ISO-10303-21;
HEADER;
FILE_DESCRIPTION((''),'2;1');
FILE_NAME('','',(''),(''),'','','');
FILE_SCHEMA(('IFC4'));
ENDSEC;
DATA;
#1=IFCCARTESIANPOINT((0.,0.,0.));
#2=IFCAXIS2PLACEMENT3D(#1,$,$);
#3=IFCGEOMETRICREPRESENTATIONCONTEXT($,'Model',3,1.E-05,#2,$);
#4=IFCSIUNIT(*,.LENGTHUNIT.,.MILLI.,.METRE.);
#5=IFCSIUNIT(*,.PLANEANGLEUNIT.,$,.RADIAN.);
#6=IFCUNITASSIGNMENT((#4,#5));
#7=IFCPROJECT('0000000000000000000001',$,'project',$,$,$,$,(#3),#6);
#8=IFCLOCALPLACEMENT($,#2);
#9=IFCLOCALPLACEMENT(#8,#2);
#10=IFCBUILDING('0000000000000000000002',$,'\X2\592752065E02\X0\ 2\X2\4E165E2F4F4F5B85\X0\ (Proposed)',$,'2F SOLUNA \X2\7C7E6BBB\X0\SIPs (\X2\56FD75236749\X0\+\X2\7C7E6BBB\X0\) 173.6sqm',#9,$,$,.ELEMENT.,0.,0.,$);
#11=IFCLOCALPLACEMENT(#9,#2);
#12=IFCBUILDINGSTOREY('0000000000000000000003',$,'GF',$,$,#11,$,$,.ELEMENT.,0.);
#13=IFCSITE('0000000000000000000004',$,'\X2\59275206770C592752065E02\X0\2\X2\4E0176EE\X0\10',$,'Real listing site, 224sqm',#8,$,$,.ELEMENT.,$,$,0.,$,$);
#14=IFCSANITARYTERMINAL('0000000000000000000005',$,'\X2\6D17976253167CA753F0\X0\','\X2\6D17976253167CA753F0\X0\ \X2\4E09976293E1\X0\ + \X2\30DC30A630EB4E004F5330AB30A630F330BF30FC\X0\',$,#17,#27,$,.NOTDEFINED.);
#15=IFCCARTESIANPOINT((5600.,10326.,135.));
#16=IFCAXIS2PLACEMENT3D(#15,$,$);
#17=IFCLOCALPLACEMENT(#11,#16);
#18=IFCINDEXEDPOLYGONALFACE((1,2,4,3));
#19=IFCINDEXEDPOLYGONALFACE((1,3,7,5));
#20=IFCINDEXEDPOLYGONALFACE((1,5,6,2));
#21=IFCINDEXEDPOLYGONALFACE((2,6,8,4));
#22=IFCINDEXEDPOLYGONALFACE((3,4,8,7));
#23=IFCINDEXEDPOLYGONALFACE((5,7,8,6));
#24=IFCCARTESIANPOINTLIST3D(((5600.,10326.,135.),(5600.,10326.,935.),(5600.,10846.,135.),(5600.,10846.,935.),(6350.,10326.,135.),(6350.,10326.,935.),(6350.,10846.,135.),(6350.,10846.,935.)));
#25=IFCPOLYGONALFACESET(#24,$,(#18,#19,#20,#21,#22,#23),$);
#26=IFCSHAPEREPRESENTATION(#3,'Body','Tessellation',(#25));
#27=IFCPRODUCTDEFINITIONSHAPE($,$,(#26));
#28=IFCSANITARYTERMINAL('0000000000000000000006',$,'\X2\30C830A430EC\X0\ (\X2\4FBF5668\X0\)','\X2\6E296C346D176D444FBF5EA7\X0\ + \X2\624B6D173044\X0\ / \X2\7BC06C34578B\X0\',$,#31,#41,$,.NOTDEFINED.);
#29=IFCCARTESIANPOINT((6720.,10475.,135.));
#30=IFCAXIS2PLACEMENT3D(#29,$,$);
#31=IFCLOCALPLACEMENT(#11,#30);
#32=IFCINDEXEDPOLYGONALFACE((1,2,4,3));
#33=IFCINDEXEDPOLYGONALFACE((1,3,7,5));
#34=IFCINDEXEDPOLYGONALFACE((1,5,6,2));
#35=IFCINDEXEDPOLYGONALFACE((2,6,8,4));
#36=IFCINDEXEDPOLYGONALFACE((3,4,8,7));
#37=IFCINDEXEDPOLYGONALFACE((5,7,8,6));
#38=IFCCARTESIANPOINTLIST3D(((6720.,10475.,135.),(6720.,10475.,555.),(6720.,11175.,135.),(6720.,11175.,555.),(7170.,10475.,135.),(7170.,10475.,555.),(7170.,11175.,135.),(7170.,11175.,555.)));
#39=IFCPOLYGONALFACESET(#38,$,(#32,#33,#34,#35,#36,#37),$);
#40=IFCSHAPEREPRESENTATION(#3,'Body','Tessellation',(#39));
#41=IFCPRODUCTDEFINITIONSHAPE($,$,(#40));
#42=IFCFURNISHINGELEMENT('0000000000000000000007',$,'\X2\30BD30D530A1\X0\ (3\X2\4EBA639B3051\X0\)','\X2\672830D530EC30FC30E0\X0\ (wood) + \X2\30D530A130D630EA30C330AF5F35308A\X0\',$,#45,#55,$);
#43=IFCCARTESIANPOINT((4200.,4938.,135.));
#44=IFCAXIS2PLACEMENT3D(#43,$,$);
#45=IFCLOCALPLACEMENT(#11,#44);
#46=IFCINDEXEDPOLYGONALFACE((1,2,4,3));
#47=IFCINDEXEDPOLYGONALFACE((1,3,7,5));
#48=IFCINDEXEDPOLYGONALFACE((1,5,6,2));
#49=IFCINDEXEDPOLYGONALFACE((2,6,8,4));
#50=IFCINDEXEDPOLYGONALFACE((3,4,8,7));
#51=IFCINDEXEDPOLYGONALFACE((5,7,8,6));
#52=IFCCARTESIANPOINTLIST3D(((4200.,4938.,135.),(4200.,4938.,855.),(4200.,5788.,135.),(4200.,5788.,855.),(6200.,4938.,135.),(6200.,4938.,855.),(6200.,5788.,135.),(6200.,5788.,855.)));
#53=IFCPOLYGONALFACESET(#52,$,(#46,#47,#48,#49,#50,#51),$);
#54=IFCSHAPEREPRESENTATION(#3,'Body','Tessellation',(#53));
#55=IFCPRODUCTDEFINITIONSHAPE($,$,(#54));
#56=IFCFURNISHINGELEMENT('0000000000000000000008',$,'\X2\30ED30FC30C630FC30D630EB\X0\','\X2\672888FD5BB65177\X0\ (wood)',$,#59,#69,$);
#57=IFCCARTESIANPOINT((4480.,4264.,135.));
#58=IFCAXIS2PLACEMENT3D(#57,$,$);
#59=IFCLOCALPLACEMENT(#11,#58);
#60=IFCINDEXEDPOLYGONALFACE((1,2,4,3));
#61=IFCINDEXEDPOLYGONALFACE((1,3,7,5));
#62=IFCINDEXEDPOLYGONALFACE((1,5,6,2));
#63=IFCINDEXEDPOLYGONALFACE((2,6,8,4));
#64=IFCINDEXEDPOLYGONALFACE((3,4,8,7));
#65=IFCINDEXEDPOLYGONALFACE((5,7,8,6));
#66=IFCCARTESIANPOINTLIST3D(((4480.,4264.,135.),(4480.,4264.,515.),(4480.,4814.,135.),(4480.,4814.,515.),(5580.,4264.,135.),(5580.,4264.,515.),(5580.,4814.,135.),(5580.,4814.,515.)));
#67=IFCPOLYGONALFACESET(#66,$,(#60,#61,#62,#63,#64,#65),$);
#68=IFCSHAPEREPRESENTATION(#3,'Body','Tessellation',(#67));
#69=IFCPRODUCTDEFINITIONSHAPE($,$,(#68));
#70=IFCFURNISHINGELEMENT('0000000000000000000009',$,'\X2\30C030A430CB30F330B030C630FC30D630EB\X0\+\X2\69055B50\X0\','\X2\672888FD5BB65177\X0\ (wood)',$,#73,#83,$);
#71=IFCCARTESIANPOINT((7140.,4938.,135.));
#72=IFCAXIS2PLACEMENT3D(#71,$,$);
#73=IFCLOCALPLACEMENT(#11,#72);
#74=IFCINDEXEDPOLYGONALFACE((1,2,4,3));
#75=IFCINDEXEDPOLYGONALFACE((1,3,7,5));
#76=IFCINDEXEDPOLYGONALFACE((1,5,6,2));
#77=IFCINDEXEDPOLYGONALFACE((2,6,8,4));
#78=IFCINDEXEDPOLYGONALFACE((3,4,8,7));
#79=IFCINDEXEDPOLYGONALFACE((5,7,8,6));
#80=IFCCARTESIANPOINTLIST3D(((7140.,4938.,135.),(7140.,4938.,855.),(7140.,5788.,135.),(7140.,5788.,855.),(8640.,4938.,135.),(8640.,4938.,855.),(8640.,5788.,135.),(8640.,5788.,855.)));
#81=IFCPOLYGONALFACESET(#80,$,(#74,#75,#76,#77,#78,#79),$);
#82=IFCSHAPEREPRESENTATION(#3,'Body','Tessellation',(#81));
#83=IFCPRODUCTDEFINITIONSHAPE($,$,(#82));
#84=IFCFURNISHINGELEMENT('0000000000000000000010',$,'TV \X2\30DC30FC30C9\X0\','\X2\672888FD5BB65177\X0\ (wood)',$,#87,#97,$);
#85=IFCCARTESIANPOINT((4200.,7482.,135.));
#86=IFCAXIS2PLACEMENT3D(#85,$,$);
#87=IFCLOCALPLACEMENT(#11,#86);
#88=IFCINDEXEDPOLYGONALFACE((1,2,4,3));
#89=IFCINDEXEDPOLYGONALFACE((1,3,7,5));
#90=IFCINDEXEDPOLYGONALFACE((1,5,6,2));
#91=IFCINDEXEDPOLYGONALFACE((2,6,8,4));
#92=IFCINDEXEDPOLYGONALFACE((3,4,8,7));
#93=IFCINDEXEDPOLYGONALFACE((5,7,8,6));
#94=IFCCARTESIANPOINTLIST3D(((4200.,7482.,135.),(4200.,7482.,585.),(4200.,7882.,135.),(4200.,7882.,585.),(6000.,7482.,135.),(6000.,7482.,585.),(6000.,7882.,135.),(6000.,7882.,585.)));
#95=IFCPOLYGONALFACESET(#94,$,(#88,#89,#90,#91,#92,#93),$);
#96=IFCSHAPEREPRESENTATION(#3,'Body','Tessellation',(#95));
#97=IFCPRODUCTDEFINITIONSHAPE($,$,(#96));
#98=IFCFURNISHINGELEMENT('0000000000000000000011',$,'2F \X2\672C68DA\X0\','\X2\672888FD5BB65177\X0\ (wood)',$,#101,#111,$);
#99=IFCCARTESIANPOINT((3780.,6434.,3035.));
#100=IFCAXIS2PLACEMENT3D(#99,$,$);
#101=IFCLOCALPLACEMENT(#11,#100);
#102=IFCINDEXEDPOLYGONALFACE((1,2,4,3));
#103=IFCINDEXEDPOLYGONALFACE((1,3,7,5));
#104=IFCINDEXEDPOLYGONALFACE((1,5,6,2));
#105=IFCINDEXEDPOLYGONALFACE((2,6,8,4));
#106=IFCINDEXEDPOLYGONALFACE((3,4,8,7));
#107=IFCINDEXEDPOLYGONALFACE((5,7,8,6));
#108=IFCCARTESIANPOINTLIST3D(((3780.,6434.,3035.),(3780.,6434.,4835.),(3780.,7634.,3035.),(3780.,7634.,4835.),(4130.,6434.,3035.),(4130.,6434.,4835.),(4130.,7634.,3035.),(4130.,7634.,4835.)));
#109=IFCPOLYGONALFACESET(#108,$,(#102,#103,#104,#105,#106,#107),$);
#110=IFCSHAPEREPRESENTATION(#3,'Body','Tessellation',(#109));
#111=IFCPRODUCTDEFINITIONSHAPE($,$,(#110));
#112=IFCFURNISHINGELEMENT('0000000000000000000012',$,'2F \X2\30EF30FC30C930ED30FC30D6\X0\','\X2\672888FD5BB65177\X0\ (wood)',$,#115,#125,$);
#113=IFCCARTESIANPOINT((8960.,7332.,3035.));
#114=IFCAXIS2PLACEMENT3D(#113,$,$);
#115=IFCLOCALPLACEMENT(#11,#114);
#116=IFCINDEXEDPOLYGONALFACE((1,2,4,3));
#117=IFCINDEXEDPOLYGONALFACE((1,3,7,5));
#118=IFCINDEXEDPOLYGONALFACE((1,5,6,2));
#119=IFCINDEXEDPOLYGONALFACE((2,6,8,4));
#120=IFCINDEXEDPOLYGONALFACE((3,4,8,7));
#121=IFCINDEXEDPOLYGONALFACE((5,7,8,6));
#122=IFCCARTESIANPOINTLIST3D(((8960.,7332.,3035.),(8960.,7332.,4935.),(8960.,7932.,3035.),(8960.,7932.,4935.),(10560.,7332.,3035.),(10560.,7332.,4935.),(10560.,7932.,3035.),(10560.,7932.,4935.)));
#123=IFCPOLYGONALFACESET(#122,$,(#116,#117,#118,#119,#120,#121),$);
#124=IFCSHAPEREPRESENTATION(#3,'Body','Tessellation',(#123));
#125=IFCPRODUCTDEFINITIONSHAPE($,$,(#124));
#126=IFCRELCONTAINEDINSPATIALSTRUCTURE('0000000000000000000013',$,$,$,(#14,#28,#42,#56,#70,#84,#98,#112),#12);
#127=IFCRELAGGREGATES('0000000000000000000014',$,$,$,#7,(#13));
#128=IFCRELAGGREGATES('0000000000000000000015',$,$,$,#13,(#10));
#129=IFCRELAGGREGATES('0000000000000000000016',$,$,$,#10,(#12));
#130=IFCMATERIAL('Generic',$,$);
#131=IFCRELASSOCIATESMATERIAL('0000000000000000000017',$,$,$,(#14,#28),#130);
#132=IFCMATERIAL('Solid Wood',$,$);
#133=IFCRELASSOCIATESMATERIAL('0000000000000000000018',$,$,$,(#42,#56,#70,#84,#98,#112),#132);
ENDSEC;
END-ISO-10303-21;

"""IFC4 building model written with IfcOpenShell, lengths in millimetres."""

from ifc_helpers import new_model, si_unit, frame, frame_2d, origin, place, context, project, spatial, rectangle, extrude, material, element, save


model = new_model("IFC4")

# Units and contexts
model_context = context("Model", 3, precision=1e-05, world=origin())
ifc_project = project(units=[si_unit("LENGTHUNIT", "METRE", prefix="MILLI"), si_unit("PLANEANGLEUNIT", "RADIAN")], contexts=[model_context])

# Site, building, storey
site_placement = place(None, origin())
site = spatial("IfcSite", under=ifc_project, at=site_placement, Name="大分県大分市2丁目10", ObjectType="Real listing site, 224sqm", CompositionType="ELEMENT", RefElevation=0.0)
building_placement = place(site_placement, origin())
building = spatial("IfcBuilding", under=site, at=building_placement, Name="大分市 2世帯住宅 (Proposed)", ObjectType="2F SOLUNA 籾殻SIPs (国産杉+籾殻) 173.6sqm", CompositionType="ELEMENT", ElevationOfRefHeight=0.0, ElevationOfTerrain=0.0)
storey_placement = place(building_placement, origin())
storey = spatial("IfcBuildingStorey", under=building, at=storey_placement, Name="GF", CompositionType="ELEMENT", Elevation=0.0)

# Shared definitions
ifc_material_1 = material(Name="Generic")

# Shared definitions
ifc_material_2 = material(Name="Solid Wood")

# Sanitary terminals
sanitary_terminal_1_placement = place(storey_placement, frame((5600.0, 10326.0, 135.0)))
element("IfcSanitaryTerminal", 1, at=sanitary_terminal_1_placement, inside=storey, material=ifc_material_1, Name="洗面化粧台", Description="洗面化粧台 三面鏡 + ボウル一体カウンター", PredefinedType="NOTDEFINED", context=model_context, shape_type="SweptSolid", body=[
    extrude(rectangle(XDim=750.0, YDim=520.0, at=frame_2d((375.0, 260.0))), frame((5600.0, 10326.0, 135.0)), (0.0, 0.0, 1.0), 800.0),
])
sanitary_terminal_2_placement = place(storey_placement, frame((6720.0, 10475.0, 135.0)))
element("IfcSanitaryTerminal", 2, at=sanitary_terminal_2_placement, inside=storey, material=ifc_material_1, Name="トイレ (便器)", Description="温水洗浄便座 + 手洗い / 節水型", PredefinedType="NOTDEFINED", context=model_context, shape_type="SweptSolid", body=[
    extrude(rectangle(XDim=450.0, YDim=700.0, at=frame_2d((225.0, 350.0))), frame((6720.0, 10475.0, 135.0)), (0.0, 0.0, 1.0), 420.0),
])

# Furnishing elements
furnishing_1_placement = place(storey_placement, frame((4200.0, 4938.0, 135.0)))
element("IfcFurnishingElement", 3, at=furnishing_1_placement, inside=storey, material=ifc_material_2, Name="ソファ (3人掛け)", Description="木フレーム (wood) + ファブリック張り", context=model_context, shape_type="SweptSolid", body=[
    extrude(rectangle(XDim=2000.0, YDim=850.0, at=frame_2d((1000.0, 425.0))), frame((4200.0, 4938.0, 135.0)), (0.0, 0.0, 1.0), 720.0),
])
furnishing_2_placement = place(storey_placement, frame((4480.0, 4264.0, 135.0)))
element("IfcFurnishingElement", 4, at=furnishing_2_placement, inside=storey, material=ifc_material_2, Name="ローテーブル", Description="木製家具 (wood)", context=model_context, shape_type="SweptSolid", body=[
    extrude(rectangle(XDim=1100.0, YDim=550.0, at=frame_2d((550.0, 275.0))), frame((4480.0, 4264.0, 135.0)), (0.0, 0.0, 1.0), 380.0),
])
furnishing_3_placement = place(storey_placement, frame((7140.0, 4938.0, 135.0)))
element("IfcFurnishingElement", 5, at=furnishing_3_placement, inside=storey, material=ifc_material_2, Name="ダイニングテーブル+椅子", Description="木製家具 (wood)", context=model_context, shape_type="SweptSolid", body=[
    extrude(rectangle(XDim=1500.0, YDim=850.0, at=frame_2d((750.0, 425.0))), frame((7140.0, 4938.0, 135.0)), (0.0, 0.0, 1.0), 720.0),
])
furnishing_4_placement = place(storey_placement, frame((4200.0, 7482.0, 135.0)))
element("IfcFurnishingElement", 6, at=furnishing_4_placement, inside=storey, material=ifc_material_2, Name="TV ボード", Description="木製家具 (wood)", context=model_context, shape_type="SweptSolid", body=[
    extrude(rectangle(XDim=1800.0, YDim=400.0, at=frame_2d((900.0, 200.0))), frame((4200.0, 7482.0, 135.0)), (0.0, 0.0, 1.0), 450.0),
])
furnishing_5_placement = place(storey_placement, frame((3780.0, 6434.0, 3035.0)))
element("IfcFurnishingElement", 7, at=furnishing_5_placement, inside=storey, material=ifc_material_2, Name="2F 本棚", Description="木製家具 (wood)", context=model_context, shape_type="SweptSolid", body=[
    extrude(rectangle(XDim=350.0, YDim=1200.0, at=frame_2d((175.0, 600.0))), frame((3780.0, 6434.0, 3035.0)), (0.0, 0.0, 1.0), 1800.0),
])
furnishing_6_placement = place(storey_placement, frame((8960.0, 7332.0, 3035.0)))
element("IfcFurnishingElement", 8, at=furnishing_6_placement, inside=storey, material=ifc_material_2, Name="2F ワードローブ", Description="木製家具 (wood)", context=model_context, shape_type="SweptSolid", body=[
    extrude(rectangle(XDim=1600.0, YDim=600.0, at=frame_2d((800.0, 300.0))), frame((8960.0, 7332.0, 3035.0)), (0.0, 0.0, 1.0), 1900.0),
])

save(model, "model.ifc")
